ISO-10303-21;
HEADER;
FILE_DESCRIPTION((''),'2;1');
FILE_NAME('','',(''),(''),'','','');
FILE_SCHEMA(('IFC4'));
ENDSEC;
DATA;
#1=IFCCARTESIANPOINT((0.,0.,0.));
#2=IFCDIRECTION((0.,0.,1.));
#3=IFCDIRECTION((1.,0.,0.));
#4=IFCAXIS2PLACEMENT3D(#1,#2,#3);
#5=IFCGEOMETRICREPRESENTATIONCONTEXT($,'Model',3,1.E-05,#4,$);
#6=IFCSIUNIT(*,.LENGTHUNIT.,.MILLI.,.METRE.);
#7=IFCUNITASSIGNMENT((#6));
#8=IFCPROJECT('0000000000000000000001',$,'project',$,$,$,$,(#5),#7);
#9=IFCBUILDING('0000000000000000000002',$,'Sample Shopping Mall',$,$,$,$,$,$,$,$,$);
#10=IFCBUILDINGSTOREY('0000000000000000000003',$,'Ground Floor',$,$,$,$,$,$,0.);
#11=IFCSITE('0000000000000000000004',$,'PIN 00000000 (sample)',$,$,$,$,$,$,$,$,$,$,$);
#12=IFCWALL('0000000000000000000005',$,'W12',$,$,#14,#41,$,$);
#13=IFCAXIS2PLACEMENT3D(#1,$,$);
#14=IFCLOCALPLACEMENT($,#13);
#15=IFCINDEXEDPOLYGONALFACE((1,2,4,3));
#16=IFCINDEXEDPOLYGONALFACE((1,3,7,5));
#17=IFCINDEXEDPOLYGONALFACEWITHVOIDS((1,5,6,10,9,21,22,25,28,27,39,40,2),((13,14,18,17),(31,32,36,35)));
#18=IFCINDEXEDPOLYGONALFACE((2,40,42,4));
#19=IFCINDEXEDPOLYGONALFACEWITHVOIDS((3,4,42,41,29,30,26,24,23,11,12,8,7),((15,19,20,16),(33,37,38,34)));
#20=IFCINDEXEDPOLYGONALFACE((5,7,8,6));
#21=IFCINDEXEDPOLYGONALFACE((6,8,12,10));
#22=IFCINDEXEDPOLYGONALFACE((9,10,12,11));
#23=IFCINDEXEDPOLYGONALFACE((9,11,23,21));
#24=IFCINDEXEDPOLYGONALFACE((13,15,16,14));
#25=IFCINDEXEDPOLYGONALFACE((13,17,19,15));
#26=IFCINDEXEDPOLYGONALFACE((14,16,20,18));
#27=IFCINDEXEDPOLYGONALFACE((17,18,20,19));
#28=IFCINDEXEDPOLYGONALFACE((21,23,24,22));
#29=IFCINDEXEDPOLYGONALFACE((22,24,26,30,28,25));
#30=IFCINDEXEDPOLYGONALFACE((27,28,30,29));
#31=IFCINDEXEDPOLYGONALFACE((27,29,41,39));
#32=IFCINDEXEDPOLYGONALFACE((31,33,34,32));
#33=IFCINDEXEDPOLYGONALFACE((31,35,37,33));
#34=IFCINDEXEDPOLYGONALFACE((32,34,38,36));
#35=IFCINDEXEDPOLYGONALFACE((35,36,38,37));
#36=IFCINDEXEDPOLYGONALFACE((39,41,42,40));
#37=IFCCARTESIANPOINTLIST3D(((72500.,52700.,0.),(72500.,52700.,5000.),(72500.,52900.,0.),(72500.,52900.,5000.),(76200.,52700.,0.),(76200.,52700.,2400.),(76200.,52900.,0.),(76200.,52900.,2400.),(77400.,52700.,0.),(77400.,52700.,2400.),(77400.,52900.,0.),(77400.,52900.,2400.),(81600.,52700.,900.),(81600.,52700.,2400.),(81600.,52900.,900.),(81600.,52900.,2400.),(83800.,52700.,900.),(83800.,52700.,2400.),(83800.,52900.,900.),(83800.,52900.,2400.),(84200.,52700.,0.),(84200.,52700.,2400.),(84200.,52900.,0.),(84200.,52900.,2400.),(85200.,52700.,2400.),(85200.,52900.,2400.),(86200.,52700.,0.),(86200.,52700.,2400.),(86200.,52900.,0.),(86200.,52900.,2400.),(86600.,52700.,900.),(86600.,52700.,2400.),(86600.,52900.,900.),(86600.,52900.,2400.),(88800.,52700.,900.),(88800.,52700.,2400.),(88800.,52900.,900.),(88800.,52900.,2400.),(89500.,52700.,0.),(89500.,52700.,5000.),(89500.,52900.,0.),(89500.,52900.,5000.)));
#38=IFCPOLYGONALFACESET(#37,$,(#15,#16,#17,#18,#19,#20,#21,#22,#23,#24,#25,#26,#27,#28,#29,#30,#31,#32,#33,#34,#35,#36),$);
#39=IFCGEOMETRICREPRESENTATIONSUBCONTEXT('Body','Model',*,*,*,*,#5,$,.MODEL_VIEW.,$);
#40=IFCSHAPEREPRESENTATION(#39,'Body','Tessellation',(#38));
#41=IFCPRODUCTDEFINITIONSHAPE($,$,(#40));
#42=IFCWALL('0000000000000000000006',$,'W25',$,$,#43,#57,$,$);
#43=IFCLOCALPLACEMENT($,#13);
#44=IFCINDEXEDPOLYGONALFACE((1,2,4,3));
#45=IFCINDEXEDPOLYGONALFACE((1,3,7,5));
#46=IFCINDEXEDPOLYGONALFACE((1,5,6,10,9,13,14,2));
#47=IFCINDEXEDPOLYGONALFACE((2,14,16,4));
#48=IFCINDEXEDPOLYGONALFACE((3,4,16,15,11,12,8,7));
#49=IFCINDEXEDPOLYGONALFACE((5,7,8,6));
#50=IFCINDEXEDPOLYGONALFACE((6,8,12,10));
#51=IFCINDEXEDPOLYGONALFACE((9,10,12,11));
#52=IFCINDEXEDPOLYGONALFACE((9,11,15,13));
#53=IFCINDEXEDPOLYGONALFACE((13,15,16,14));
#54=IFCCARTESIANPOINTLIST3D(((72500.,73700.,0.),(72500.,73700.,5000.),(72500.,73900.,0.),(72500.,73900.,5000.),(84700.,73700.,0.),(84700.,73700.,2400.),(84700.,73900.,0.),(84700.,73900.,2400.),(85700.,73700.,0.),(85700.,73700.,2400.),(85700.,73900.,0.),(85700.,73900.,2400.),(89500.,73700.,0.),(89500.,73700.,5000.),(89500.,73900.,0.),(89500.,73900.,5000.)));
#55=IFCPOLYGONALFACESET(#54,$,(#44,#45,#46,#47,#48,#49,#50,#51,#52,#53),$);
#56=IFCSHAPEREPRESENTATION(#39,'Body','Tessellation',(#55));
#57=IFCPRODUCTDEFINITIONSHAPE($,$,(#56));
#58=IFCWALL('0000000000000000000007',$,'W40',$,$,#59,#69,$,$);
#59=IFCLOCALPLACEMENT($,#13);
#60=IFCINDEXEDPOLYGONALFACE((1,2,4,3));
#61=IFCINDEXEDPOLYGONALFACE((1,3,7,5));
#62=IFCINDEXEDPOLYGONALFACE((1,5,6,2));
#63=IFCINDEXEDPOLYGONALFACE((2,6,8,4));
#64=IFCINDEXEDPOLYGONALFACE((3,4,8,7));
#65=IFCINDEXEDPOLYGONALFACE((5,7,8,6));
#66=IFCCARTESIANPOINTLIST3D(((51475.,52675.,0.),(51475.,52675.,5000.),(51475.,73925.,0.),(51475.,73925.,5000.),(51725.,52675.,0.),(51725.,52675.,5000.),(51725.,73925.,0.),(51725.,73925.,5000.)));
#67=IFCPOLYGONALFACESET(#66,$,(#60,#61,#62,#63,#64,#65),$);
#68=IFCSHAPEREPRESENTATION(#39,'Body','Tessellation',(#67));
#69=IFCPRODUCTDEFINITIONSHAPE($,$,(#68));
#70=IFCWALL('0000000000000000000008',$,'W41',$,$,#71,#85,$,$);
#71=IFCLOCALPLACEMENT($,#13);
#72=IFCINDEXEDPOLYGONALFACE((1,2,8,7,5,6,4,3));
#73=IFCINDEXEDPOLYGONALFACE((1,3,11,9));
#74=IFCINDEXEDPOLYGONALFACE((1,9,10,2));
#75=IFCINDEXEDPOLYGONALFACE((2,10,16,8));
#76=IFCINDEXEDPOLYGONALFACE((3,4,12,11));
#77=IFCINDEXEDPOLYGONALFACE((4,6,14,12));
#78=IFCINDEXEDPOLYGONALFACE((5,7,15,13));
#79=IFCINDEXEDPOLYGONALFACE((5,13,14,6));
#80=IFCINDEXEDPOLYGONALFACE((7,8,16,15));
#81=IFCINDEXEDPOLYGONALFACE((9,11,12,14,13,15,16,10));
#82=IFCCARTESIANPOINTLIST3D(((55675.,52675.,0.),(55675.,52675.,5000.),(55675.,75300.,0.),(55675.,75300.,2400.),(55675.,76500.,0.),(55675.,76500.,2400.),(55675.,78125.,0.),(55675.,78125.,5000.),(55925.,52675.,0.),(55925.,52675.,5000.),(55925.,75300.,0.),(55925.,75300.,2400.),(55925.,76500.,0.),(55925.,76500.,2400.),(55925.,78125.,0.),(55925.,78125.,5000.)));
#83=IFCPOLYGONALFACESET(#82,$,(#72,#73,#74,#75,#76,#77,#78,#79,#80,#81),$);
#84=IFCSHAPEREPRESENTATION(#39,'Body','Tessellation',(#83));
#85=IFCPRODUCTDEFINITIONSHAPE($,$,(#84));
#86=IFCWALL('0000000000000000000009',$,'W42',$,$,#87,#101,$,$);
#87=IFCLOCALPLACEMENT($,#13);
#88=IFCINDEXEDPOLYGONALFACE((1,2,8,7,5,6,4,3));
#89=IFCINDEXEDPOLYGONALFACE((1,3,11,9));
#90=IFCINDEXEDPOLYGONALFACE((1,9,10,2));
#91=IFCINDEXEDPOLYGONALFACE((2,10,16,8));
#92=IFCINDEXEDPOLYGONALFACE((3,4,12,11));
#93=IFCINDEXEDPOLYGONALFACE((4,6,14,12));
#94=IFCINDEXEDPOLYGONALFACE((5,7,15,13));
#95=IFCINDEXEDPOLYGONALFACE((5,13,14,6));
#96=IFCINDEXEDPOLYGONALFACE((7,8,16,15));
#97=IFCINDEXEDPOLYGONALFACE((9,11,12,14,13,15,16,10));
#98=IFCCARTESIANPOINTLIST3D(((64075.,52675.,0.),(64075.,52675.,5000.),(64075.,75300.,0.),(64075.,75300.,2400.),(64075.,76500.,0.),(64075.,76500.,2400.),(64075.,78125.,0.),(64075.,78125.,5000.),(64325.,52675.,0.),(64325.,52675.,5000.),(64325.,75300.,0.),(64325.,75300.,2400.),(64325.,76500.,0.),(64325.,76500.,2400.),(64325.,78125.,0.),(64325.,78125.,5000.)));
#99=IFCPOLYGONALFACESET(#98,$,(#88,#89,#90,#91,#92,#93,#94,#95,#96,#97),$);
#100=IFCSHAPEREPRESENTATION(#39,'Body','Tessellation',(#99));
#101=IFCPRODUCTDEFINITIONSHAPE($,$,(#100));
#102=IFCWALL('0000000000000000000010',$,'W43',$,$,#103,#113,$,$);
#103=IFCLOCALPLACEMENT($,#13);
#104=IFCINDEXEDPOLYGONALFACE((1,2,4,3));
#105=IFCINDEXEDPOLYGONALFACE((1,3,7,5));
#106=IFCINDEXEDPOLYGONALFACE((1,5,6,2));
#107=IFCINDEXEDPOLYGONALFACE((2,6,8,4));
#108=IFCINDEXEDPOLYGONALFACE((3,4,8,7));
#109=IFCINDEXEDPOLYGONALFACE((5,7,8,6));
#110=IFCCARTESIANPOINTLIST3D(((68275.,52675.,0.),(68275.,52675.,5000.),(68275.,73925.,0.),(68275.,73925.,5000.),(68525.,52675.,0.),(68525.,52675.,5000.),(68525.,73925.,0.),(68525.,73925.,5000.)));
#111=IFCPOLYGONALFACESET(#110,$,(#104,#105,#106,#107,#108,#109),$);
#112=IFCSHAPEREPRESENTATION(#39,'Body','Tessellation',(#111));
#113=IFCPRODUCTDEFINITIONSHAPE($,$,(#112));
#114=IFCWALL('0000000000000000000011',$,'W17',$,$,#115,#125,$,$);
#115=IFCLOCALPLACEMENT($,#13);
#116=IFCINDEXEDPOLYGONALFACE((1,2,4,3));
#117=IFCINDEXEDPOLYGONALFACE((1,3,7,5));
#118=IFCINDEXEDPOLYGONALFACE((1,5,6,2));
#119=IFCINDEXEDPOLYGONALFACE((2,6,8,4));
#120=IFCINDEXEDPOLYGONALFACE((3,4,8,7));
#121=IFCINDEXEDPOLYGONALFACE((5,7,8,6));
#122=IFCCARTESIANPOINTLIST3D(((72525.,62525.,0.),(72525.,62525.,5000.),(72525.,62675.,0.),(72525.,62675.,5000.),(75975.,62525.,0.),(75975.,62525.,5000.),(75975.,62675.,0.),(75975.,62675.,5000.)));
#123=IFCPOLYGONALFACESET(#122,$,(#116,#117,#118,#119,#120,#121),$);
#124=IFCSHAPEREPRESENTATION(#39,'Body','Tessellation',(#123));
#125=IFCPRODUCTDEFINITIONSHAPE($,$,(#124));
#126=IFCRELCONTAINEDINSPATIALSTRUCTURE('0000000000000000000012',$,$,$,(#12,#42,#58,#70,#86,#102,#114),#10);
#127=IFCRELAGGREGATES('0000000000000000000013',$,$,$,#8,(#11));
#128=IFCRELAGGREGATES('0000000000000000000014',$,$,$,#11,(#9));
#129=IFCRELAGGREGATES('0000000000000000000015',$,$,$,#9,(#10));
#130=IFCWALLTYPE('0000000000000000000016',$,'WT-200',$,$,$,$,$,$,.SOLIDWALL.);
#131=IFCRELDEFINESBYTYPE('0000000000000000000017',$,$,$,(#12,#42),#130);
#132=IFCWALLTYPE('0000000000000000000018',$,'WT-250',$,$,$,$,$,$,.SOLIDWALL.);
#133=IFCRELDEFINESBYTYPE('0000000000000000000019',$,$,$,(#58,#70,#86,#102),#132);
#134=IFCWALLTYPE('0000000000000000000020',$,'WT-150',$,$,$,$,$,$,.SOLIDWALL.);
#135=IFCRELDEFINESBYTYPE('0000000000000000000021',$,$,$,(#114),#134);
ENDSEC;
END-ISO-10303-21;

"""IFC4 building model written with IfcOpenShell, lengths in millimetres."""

from ifc_helpers import new_model, si_unit, frame, origin_with_axes, place, context, subcontext, project, spatial, indexed_curve, outline, extrude, type_object, element, save


model = new_model("IFC4")

# Units and contexts
model_context = context("Model", 3, precision=1e-05, world=origin_with_axes())
body_context = subcontext(model_context, "Body", "Model", "MODEL_VIEW")
ifc_project = project(units=[si_unit("LENGTHUNIT", "METRE", prefix="MILLI")], contexts=[model_context])

# Site, building, storey
site = spatial("IfcSite", under=ifc_project, Name="PIN 00000000 (sample)")
building = spatial("IfcBuilding", under=site, Name="Sample Shopping Mall")
storey = spatial("IfcBuildingStorey", under=building, Name="Ground Floor", Elevation=0.0)

# Wall, openings
wall_type_1 = type_object("IfcWallType", Name="WT-200", PredefinedType="SOLIDWALL")
wall_1_placement = place(None, frame((72500.0, 52700.0, 0.0), z_axis=(0.0, 0.0, 1.0), x_axis=(1.0, 0.0, 0.0)))
wall_1 = element("IfcWall", 1, at=wall_1_placement, inside=storey, type_object=wall_type_1, Name="W12", context=body_context, shape_type="SweptSolid", body=[
    extrude(outline(indexed_curve([(0.0, 0.0), (0.0, 200.0), (17000.0, 200.0), (17000.0, 0.0), (0.0, 0.0)], self_intersect=False)), origin_with_axes(), (0.0, 0.0, 1.0), 5000.0),
])
opening_1_placement = place(wall_1_placement, frame((3700.0, -100.0, 0.0), z_axis=(0.0, 0.0, 1.0), x_axis=(1.0, 0.0, 0.0)))
element("IfcOpeningElement", 2, at=opening_1_placement, cuts=wall_1, context=body_context, shape_type="SweptSolid", body=[
    extrude(outline(indexed_curve([(0.0, 0.0), (0.0, 400.0), (1200.0, 400.0), (1200.0, 0.0), (0.0, 0.0)], self_intersect=False)), origin_with_axes(), (0.0, 0.0, 1.0), 2400.0),
])
opening_2_placement = place(wall_1_placement, frame((11700.0, -100.0, 0.0), z_axis=(0.0, 0.0, 1.0), x_axis=(1.0, 0.0, 0.0)))
element("IfcOpeningElement", 3, at=opening_2_placement, cuts=wall_1, context=body_context, shape_type="SweptSolid", body=[
    extrude(outline(indexed_curve([(0.0, 0.0), (0.0, 400.0), (1000.0, 400.0), (1000.0, 0.0), (0.0, 0.0)], self_intersect=False)), origin_with_axes(), (0.0, 0.0, 1.0), 2400.0),
])
opening_3_placement = place(wall_1_placement, frame((12700.0, -100.0, 0.0), z_axis=(0.0, 0.0, 1.0), x_axis=(1.0, 0.0, 0.0)))
element("IfcOpeningElement", 4, at=opening_3_placement, cuts=wall_1, context=body_context, shape_type="SweptSolid", body=[
    extrude(outline(indexed_curve([(0.0, 0.0), (0.0, 400.0), (1000.0, 400.0), (1000.0, 0.0), (0.0, 0.0)], self_intersect=False)), origin_with_axes(), (0.0, 0.0, 1.0), 2400.0),
])
opening_4_placement = place(wall_1_placement, frame((9100.0, -100.0, 900.0), z_axis=(0.0, 0.0, 1.0), x_axis=(1.0, 0.0, 0.0)))
element("IfcOpeningElement", 5, at=opening_4_placement, cuts=wall_1, context=body_context, shape_type="SweptSolid", body=[
    extrude(outline(indexed_curve([(0.0, 0.0), (0.0, 400.0), (2200.0, 400.0), (2200.0, 0.0), (0.0, 0.0)], self_intersect=False)), origin_with_axes(), (0.0, 0.0, 1.0), 1500.0),
])
opening_5_placement = place(wall_1_placement, frame((14100.0, -100.0, 900.0), z_axis=(0.0, 0.0, 1.0), x_axis=(1.0, 0.0, 0.0)))
element("IfcOpeningElement", 6, at=opening_5_placement, cuts=wall_1, context=body_context, shape_type="SweptSolid", body=[
    extrude(outline(indexed_curve([(0.0, 0.0), (0.0, 400.0), (2200.0, 400.0), (2200.0, 0.0), (0.0, 0.0)], self_intersect=False)), origin_with_axes(), (0.0, 0.0, 1.0), 1500.0),
])

# Wall, opening
wall_2_placement = place(None, frame((72500.0, 73700.0, 0.0), z_axis=(0.0, 0.0, 1.0), x_axis=(1.0, 0.0, 0.0)))
wall_2 = element("IfcWall", 7, at=wall_2_placement, inside=storey, type_object=wall_type_1, Name="W25", context=body_context, shape_type="SweptSolid", body=[
    extrude(outline(indexed_curve([(0.0, 0.0), (0.0, 200.0), (17000.0, 200.0), (17000.0, 0.0), (0.0, 0.0)], self_intersect=False)), origin_with_axes(), (0.0, 0.0, 1.0), 5000.0),
])
opening_6_placement = place(wall_2_placement, frame((12200.0, -100.0, 0.0), z_axis=(0.0, 0.0, 1.0), x_axis=(1.0, 0.0, 0.0)))
element("IfcOpeningElement", 8, at=opening_6_placement, cuts=wall_2, context=body_context, shape_type="SweptSolid", body=[
    extrude(outline(indexed_curve([(0.0, 0.0), (0.0, 400.0), (1000.0, 400.0), (1000.0, 0.0), (0.0, 0.0)], self_intersect=False)), origin_with_axes(), (0.0, 0.0, 1.0), 2400.0),
])

# Shared definitions
wall_type_2 = type_object("IfcWallType", Name="WT-250", PredefinedType="SOLIDWALL")

# Wall
wall_3_placement = place(None, frame((51725.0, 52675.0, 0.0), z_axis=(0.0, 0.0, 1.0), x_axis=(0.0, 1.0, 0.0)))
element("IfcWall", 9, at=wall_3_placement, inside=storey, type_object=wall_type_2, Name="W40", context=body_context, shape_type="SweptSolid", body=[
    extrude(outline(indexed_curve([(0.0, 0.0), (0.0, 250.0), (21250.0, 250.0), (21250.0, 0.0), (0.0, 0.0)], self_intersect=False)), origin_with_axes(), (0.0, 0.0, 1.0), 5000.0),
])

# Walls, openings
wall_4_placement = place(None, frame((55925.0, 52675.0, 0.0), z_axis=(0.0, 0.0, 1.0), x_axis=(0.0, 1.0, 0.0)))
wall_4 = element("IfcWall", 10, at=wall_4_placement, inside=storey, type_object=wall_type_2, Name="W41", context=body_context, shape_type="SweptSolid", body=[
    extrude(outline(indexed_curve([(0.0, 0.0), (0.0, 250.0), (25450.0, 250.0), (25450.0, 0.0), (0.0, 0.0)], self_intersect=False)), origin_with_axes(), (0.0, 0.0, 1.0), 5000.0),
])
opening_7_placement = place(wall_4_placement, frame((22625.0, -100.0, 0.0), z_axis=(0.0, 0.0, 1.0), x_axis=(1.0, 0.0, 0.0)))
element("IfcOpeningElement", 11, at=opening_7_placement, cuts=wall_4, context=body_context, shape_type="SweptSolid", body=[
    extrude(outline(indexed_curve([(0.0, 0.0), (0.0, 450.0), (1200.0, 450.0), (1200.0, 0.0), (0.0, 0.0)], self_intersect=False)), origin_with_axes(), (0.0, 0.0, 1.0), 2400.0),
])
wall_5_placement = place(None, frame((64325.0, 52675.0, 0.0), z_axis=(0.0, 0.0, 1.0), x_axis=(0.0, 1.0, 0.0)))
wall_5 = element("IfcWall", 12, at=wall_5_placement, inside=storey, type_object=wall_type_2, Name="W42", context=body_context, shape_type="SweptSolid", body=[
    extrude(outline(indexed_curve([(0.0, 0.0), (0.0, 250.0), (25450.0, 250.0), (25450.0, 0.0), (0.0, 0.0)], self_intersect=False)), origin_with_axes(), (0.0, 0.0, 1.0), 5000.0),
])
opening_8_placement = place(wall_5_placement, frame((22625.0, -100.0, 0.0), z_axis=(0.0, 0.0, 1.0), x_axis=(1.0, 0.0, 0.0)))
element("IfcOpeningElement", 13, at=opening_8_placement, cuts=wall_5, context=body_context, shape_type="SweptSolid", body=[
    extrude(outline(indexed_curve([(0.0, 0.0), (0.0, 450.0), (1200.0, 450.0), (1200.0, 0.0), (0.0, 0.0)], self_intersect=False)), origin_with_axes(), (0.0, 0.0, 1.0), 2400.0),
])

# Walls
wall_6_placement = place(None, frame((68525.0, 52675.0, 0.0), z_axis=(0.0, 0.0, 1.0), x_axis=(0.0, 1.0, 0.0)))
element("IfcWall", 14, at=wall_6_placement, inside=storey, type_object=wall_type_2, Name="W43", context=body_context, shape_type="SweptSolid", body=[
    extrude(outline(indexed_curve([(0.0, 0.0), (0.0, 250.0), (21250.0, 250.0), (21250.0, 0.0), (0.0, 0.0)], self_intersect=False)), origin_with_axes(), (0.0, 0.0, 1.0), 5000.0),
])
wall_type_3 = type_object("IfcWallType", Name="WT-150", PredefinedType="SOLIDWALL")
wall_7_placement = place(None, frame((72525.0, 62525.0, 0.0), z_axis=(0.0, 0.0, 1.0), x_axis=(1.0, 0.0, 0.0)))
element("IfcWall", 15, at=wall_7_placement, inside=storey, type_object=wall_type_3, Name="W17", context=body_context, shape_type="SweptSolid", body=[
    extrude(outline(indexed_curve([(0.0, 0.0), (0.0, 150.0), (3450.0, 150.0), (3450.0, 0.0), (0.0, 0.0)], self_intersect=False)), origin_with_axes(), (0.0, 0.0, 1.0), 5000.0),
])

save(model, "model.ifc")
